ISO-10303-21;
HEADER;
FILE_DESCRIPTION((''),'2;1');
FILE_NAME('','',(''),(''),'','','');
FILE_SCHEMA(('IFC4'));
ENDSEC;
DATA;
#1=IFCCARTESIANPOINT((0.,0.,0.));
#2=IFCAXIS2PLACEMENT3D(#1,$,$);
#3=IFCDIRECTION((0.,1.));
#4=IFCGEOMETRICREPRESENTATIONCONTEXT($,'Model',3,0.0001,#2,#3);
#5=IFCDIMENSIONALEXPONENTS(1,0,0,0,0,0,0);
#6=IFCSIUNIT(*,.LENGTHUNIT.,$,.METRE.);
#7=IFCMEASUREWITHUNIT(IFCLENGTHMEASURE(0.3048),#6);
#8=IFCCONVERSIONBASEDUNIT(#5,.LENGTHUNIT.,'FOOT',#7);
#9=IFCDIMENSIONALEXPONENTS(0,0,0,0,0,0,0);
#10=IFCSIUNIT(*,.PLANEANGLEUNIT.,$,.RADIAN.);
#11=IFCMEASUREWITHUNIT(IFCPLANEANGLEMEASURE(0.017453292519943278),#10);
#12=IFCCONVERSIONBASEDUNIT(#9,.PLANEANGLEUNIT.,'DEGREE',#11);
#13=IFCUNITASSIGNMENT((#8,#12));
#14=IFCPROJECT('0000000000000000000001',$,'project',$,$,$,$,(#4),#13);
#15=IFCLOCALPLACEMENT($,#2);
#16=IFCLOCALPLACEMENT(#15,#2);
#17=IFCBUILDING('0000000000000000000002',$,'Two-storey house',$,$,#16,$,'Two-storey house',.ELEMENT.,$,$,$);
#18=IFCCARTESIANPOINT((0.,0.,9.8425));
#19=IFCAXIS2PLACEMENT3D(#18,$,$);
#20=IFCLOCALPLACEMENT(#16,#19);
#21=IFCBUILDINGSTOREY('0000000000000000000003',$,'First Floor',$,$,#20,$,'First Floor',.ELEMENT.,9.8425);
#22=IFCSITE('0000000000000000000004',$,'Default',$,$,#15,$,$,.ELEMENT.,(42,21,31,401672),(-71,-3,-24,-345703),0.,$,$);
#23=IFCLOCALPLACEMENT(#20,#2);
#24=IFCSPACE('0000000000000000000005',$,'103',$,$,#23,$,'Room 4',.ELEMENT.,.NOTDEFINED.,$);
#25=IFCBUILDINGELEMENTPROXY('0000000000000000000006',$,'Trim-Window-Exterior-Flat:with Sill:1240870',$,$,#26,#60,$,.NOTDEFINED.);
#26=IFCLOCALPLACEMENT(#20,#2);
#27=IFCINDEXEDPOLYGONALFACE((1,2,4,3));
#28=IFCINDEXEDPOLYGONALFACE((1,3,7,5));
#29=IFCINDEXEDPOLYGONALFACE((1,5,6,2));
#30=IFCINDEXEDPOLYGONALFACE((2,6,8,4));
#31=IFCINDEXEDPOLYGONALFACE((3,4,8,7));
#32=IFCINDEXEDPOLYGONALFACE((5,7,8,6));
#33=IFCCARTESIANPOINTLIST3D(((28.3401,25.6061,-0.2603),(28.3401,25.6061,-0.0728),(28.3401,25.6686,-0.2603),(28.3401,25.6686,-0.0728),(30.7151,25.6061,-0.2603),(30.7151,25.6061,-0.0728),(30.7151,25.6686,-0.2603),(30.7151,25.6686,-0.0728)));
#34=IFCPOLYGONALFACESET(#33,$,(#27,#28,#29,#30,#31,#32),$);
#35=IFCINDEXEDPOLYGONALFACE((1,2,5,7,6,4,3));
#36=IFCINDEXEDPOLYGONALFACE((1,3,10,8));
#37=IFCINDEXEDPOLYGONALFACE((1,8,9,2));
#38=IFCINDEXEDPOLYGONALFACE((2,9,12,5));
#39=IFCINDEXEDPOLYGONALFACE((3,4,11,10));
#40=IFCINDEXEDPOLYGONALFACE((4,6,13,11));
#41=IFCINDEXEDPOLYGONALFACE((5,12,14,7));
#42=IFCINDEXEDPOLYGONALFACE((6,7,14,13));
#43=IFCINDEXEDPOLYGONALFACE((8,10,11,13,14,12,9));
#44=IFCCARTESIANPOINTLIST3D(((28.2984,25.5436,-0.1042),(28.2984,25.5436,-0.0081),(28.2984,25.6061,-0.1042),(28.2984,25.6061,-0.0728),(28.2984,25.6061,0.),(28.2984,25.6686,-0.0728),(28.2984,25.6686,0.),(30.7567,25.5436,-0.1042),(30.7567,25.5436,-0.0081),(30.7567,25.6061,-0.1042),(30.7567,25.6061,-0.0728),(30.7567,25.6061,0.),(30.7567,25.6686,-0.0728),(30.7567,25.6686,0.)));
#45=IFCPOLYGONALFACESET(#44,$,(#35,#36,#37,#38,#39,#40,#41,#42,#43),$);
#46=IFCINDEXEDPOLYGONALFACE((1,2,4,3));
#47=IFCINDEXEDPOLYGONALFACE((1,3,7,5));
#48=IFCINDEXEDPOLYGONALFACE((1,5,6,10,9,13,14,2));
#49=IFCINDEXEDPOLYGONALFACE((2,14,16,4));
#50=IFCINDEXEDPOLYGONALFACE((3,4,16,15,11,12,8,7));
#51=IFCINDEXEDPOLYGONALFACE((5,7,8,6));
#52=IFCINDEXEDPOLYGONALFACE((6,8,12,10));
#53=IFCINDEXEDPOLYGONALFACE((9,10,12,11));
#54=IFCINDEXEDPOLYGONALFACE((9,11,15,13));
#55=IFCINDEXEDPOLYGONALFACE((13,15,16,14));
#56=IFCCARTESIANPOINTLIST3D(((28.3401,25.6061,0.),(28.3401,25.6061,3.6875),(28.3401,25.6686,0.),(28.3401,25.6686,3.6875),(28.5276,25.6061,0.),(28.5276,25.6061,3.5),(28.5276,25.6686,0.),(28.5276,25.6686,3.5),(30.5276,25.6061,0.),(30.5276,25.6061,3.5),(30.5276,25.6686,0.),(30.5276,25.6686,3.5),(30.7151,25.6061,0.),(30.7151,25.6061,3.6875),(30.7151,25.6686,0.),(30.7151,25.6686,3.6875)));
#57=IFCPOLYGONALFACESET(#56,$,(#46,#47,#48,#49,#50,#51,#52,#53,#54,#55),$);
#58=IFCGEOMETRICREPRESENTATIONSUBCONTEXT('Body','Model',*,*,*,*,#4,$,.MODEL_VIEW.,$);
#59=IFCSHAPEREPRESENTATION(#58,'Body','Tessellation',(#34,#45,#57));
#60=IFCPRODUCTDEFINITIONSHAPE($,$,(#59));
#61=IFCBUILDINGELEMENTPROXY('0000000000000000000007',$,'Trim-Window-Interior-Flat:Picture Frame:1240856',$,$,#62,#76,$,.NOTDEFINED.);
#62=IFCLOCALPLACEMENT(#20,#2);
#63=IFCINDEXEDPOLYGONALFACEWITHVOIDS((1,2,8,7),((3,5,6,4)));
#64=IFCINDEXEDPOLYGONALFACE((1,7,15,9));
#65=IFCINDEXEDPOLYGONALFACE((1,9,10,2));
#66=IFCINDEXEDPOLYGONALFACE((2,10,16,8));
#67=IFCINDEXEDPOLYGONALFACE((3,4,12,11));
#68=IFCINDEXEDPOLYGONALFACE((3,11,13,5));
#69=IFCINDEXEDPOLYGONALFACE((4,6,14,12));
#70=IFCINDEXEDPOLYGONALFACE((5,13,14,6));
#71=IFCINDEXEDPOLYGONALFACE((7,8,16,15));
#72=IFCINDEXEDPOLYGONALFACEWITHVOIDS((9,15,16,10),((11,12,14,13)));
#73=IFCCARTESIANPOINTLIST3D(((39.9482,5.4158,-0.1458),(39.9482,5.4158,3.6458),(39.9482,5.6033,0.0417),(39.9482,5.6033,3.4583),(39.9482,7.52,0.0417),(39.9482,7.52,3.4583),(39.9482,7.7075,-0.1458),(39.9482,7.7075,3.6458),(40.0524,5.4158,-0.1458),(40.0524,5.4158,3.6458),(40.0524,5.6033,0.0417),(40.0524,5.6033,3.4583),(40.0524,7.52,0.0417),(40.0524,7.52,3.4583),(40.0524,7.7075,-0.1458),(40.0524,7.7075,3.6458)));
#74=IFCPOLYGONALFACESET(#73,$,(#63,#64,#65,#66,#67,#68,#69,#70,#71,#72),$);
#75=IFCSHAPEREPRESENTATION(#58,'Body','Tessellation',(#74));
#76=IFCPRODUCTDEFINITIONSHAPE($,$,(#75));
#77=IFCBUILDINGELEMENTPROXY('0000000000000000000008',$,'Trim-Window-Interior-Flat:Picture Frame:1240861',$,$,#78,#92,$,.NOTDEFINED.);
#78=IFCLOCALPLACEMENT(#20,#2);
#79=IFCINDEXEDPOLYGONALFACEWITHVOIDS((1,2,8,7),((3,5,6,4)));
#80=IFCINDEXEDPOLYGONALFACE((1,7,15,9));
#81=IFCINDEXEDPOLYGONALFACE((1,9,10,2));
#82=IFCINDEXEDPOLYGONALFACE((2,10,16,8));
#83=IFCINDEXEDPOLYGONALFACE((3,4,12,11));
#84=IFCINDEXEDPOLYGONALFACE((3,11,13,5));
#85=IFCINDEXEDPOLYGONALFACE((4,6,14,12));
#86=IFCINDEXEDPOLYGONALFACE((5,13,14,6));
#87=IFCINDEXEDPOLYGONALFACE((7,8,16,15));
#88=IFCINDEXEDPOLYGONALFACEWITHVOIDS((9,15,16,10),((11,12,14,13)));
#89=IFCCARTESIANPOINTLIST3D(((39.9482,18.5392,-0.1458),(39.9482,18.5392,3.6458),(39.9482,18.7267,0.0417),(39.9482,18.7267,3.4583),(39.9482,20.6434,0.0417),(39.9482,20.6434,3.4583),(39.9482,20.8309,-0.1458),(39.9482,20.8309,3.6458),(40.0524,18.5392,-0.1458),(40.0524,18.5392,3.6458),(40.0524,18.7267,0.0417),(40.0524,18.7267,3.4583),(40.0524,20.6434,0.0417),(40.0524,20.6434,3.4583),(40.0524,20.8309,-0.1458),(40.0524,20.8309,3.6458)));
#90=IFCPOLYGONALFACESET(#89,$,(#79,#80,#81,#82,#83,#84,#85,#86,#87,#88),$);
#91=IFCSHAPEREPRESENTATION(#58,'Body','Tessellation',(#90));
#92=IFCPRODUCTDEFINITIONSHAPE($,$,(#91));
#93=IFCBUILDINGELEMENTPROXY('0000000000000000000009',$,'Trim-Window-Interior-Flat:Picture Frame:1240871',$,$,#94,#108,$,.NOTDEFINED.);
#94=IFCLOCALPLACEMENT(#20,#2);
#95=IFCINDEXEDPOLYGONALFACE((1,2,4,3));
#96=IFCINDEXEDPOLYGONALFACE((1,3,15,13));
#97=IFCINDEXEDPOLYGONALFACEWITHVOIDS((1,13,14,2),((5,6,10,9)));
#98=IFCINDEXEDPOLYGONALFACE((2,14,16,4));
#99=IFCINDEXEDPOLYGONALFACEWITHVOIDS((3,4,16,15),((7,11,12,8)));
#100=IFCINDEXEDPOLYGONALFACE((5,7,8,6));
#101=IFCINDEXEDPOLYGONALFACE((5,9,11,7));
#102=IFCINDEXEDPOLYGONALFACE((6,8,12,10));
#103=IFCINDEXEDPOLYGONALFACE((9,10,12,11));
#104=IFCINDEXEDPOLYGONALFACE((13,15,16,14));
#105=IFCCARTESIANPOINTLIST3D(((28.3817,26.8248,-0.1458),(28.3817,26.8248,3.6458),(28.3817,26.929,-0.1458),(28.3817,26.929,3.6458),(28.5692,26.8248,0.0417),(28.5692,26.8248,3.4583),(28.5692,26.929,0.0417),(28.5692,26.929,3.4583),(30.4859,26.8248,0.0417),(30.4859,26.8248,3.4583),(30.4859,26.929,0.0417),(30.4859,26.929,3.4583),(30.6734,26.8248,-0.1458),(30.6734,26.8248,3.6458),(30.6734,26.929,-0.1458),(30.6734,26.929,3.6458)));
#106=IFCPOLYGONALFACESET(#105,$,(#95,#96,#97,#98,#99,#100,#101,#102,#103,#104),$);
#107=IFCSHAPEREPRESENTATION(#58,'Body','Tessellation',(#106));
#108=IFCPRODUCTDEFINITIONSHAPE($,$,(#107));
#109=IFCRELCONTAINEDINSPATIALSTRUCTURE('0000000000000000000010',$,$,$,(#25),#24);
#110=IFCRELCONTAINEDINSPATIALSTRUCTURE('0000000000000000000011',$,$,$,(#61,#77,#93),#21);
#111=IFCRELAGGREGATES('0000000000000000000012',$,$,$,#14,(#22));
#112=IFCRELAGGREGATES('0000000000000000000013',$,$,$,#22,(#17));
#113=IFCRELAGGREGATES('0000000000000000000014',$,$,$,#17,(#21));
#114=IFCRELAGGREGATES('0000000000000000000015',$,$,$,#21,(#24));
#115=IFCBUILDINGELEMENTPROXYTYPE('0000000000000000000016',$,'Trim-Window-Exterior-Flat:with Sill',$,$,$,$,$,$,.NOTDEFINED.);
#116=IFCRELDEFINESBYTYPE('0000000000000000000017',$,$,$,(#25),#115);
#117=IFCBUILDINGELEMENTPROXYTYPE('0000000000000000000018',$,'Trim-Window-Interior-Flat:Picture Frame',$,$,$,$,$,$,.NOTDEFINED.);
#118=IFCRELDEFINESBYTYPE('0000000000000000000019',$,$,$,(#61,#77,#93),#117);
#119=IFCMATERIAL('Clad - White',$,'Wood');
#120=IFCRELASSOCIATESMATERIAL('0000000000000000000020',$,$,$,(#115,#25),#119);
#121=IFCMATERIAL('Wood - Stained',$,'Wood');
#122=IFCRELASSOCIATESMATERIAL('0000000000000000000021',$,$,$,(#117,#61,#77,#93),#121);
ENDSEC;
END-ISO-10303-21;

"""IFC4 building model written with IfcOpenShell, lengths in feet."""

from ifc_helpers import new_model, entity, si_unit, converted_unit, direction, frame, origin, place, context, subcontext, project, spatial, indexed_curve, outline, extrude, source, transform, mapped, material, type_object, type_shapes, element, save


model = new_model("IFC4")

# Units and contexts
model_context = context("Model", 3, precision=0.0001, world=origin(), true_north=direction((0.0, 1.0)))
body_context = subcontext(model_context, "Body", "Model", "MODEL_VIEW")
ifc_project = project(units=[converted_unit("LENGTHUNIT", "FOOT", entity("IfcLengthMeasure", 0.3048), si_unit("LENGTHUNIT", "METRE"), dimensions=[1, 0, 0, 0, 0, 0, 0]), converted_unit("PLANEANGLEUNIT", "DEGREE", entity("IfcPlaneAngleMeasure", 0.017453292519943278), si_unit("PLANEANGLEUNIT", "RADIAN"), dimensions=[0, 0, 0, 0, 0, 0, 0])], contexts=[model_context])

# Site, building, storey
site_placement = place(None, origin())
site = spatial("IfcSite", under=ifc_project, at=site_placement, Name="Default", CompositionType="ELEMENT", RefLatitude=(42, 21, 31, 401672), RefLongitude=(-71, -3, -24, -345703), RefElevation=0.0)
building_placement = place(site_placement, origin())
building = spatial("IfcBuilding", under=site, at=building_placement, Name="Two-storey house", LongName="Two-storey house", CompositionType="ELEMENT")
storey_placement = place(building_placement, frame((0.0, 0.0, 9.8425)))
storey = spatial("IfcBuildingStorey", under=building, at=storey_placement, Name="First Floor", LongName="First Floor", CompositionType="ELEMENT", Elevation=9.8425)

# Shared definitions
ifc_material_1 = material(Name="Wood - Stained", Category="Wood")

# Shared definitions
ifc_material_2 = material(Name="Clad - White", Category="Wood")

# Shared definitions
space_placement = place(storey_placement, origin())
space = spatial("IfcSpace", under=storey, at=space_placement, Name="103", LongName="Room 4", CompositionType="ELEMENT", PredefinedType="NOTDEFINED")

# Building element proxies
building_element_proxy_type_1 = type_object("IfcBuildingElementProxyType", Name="Trim-Window-Exterior-Flat:with Sill", PredefinedType="NOTDEFINED", material=ifc_material_2)
shared_shape_1 = source(origin(), body_context, "Body", "SweptSolid", [
    extrude(outline(indexed_curve([(-1.1875, -0.0938), (1.1875, -0.0938), (1.1875, 0.0938), (-1.1875, 0.0938), (-1.1875, -0.0938)], self_intersect=False)), frame((0.0, -3.6665, 0.0), z_axis=(0.0, 0.0, 1.0), x_axis=(-1.0, 0.0, 0.0)), (0.0, 0.0, 1.0), 0.0625),
    extrude(outline(indexed_curve([(-0.0625, -0.0525), (0.0, -0.0525), (0.0, -0.0211), (0.0625, -0.0211), (0.0625, 0.0517), (0.0, 0.0517), (-0.0625, 0.0436), (-0.0625, -0.0525)], self_intersect=False)), frame((-1.2292, -3.5517, 0.0625), z_axis=(1.0, 0.0, 0.0), x_axis=(0.0, 0.0, -1.0)), (0.0, 0.0, 1.0), 2.4583),
    extrude(outline(indexed_curve([(-1.8906, -1.1875), (1.7969, -1.1875), (1.7969, -1.0), (-1.7031, -1.0), (-1.7031, 1.0), (1.7969, 1.0), (1.7969, 1.1875), (-1.8906, 1.1875), (-1.8906, -1.1875)], self_intersect=False)), frame((0.0, -1.7031, 0.0), z_axis=(0.0, 0.0, 1.0), x_axis=(0.0, -1.0, 0.0)), (0.0, 0.0, 1.0), 0.0625),
])
type_shapes(building_element_proxy_type_1, [shared_shape_1])
for number, where, z_axis, x_axis, name in (
    (1, (29.5276, 25.6686, 3.5), (0.0, -1.0, 0.0), (1.0, 0.0, 0.0), "Trim-Window-Exterior-Flat:with Sill:1240870"),
):
    element("IfcBuildingElementProxy", number, at=place(space_placement, frame(where, z_axis=z_axis, x_axis=x_axis)), inside=space, type_object=building_element_proxy_type_1, material=ifc_material_2, Name=name, PredefinedType="NOTDEFINED", context=body_context, shape_type="MappedRepresentation", body=[
        mapped(shared_shape_1, transform((0.0, 0.0, 0.0), scale=1.0)),
    ])
building_element_proxy_type_2 = type_object("IfcBuildingElementProxyType", Name="Trim-Window-Interior-Flat:Picture Frame", PredefinedType="NOTDEFINED", material=ifc_material_1)
shared_shape_2 = source(origin(), body_context, "Body", "SweptSolid", [
    extrude(outline(indexed_curve([(-1.1458, -1.8958), (1.1458, -1.8958), (1.1458, 1.8958), (-1.1458, 1.8958), (-1.1458, -1.8958)], self_intersect=False), holes=[indexed_curve([(-0.9583, -1.7083), (-0.9583, 1.7083), (0.9583, 1.7083), (0.9583, -1.7083), (-0.9583, -1.7083)], self_intersect=False)]), frame((0.0, -1.75, 0.0), z_axis=(0.0, 0.0, 1.0), x_axis=(-1.0, 0.0, 0.0)), (0.0, 0.0, 1.0), 0.1042),
])
type_shapes(building_element_proxy_type_2, [shared_shape_2])
for number, where, z_axis, x_axis, name in (
    (2, (39.9482, 6.5617, 3.5), (1.0, 0.0, 0.0), (0.0, 1.0, 0.0), "Trim-Window-Interior-Flat:Picture Frame:1240856"),
    (3, (39.9482, 19.685, 3.5), (1.0, 0.0, 0.0), (0.0, 1.0, 0.0), "Trim-Window-Interior-Flat:Picture Frame:1240861"),
    (4, (29.5276, 26.8248, 3.5), (0.0, 1.0, 0.0), (-1.0, 0.0, 0.0), "Trim-Window-Interior-Flat:Picture Frame:1240871"),
):
    element("IfcBuildingElementProxy", number, at=place(storey_placement, frame(where, z_axis=z_axis, x_axis=x_axis)), inside=storey, type_object=building_element_proxy_type_2, material=ifc_material_1, Name=name, PredefinedType="NOTDEFINED", context=body_context, shape_type="MappedRepresentation", body=[
        mapped(shared_shape_2, transform((0.0, 0.0, 0.0), scale=1.0)),
    ])

save(model, "model.ifc")
